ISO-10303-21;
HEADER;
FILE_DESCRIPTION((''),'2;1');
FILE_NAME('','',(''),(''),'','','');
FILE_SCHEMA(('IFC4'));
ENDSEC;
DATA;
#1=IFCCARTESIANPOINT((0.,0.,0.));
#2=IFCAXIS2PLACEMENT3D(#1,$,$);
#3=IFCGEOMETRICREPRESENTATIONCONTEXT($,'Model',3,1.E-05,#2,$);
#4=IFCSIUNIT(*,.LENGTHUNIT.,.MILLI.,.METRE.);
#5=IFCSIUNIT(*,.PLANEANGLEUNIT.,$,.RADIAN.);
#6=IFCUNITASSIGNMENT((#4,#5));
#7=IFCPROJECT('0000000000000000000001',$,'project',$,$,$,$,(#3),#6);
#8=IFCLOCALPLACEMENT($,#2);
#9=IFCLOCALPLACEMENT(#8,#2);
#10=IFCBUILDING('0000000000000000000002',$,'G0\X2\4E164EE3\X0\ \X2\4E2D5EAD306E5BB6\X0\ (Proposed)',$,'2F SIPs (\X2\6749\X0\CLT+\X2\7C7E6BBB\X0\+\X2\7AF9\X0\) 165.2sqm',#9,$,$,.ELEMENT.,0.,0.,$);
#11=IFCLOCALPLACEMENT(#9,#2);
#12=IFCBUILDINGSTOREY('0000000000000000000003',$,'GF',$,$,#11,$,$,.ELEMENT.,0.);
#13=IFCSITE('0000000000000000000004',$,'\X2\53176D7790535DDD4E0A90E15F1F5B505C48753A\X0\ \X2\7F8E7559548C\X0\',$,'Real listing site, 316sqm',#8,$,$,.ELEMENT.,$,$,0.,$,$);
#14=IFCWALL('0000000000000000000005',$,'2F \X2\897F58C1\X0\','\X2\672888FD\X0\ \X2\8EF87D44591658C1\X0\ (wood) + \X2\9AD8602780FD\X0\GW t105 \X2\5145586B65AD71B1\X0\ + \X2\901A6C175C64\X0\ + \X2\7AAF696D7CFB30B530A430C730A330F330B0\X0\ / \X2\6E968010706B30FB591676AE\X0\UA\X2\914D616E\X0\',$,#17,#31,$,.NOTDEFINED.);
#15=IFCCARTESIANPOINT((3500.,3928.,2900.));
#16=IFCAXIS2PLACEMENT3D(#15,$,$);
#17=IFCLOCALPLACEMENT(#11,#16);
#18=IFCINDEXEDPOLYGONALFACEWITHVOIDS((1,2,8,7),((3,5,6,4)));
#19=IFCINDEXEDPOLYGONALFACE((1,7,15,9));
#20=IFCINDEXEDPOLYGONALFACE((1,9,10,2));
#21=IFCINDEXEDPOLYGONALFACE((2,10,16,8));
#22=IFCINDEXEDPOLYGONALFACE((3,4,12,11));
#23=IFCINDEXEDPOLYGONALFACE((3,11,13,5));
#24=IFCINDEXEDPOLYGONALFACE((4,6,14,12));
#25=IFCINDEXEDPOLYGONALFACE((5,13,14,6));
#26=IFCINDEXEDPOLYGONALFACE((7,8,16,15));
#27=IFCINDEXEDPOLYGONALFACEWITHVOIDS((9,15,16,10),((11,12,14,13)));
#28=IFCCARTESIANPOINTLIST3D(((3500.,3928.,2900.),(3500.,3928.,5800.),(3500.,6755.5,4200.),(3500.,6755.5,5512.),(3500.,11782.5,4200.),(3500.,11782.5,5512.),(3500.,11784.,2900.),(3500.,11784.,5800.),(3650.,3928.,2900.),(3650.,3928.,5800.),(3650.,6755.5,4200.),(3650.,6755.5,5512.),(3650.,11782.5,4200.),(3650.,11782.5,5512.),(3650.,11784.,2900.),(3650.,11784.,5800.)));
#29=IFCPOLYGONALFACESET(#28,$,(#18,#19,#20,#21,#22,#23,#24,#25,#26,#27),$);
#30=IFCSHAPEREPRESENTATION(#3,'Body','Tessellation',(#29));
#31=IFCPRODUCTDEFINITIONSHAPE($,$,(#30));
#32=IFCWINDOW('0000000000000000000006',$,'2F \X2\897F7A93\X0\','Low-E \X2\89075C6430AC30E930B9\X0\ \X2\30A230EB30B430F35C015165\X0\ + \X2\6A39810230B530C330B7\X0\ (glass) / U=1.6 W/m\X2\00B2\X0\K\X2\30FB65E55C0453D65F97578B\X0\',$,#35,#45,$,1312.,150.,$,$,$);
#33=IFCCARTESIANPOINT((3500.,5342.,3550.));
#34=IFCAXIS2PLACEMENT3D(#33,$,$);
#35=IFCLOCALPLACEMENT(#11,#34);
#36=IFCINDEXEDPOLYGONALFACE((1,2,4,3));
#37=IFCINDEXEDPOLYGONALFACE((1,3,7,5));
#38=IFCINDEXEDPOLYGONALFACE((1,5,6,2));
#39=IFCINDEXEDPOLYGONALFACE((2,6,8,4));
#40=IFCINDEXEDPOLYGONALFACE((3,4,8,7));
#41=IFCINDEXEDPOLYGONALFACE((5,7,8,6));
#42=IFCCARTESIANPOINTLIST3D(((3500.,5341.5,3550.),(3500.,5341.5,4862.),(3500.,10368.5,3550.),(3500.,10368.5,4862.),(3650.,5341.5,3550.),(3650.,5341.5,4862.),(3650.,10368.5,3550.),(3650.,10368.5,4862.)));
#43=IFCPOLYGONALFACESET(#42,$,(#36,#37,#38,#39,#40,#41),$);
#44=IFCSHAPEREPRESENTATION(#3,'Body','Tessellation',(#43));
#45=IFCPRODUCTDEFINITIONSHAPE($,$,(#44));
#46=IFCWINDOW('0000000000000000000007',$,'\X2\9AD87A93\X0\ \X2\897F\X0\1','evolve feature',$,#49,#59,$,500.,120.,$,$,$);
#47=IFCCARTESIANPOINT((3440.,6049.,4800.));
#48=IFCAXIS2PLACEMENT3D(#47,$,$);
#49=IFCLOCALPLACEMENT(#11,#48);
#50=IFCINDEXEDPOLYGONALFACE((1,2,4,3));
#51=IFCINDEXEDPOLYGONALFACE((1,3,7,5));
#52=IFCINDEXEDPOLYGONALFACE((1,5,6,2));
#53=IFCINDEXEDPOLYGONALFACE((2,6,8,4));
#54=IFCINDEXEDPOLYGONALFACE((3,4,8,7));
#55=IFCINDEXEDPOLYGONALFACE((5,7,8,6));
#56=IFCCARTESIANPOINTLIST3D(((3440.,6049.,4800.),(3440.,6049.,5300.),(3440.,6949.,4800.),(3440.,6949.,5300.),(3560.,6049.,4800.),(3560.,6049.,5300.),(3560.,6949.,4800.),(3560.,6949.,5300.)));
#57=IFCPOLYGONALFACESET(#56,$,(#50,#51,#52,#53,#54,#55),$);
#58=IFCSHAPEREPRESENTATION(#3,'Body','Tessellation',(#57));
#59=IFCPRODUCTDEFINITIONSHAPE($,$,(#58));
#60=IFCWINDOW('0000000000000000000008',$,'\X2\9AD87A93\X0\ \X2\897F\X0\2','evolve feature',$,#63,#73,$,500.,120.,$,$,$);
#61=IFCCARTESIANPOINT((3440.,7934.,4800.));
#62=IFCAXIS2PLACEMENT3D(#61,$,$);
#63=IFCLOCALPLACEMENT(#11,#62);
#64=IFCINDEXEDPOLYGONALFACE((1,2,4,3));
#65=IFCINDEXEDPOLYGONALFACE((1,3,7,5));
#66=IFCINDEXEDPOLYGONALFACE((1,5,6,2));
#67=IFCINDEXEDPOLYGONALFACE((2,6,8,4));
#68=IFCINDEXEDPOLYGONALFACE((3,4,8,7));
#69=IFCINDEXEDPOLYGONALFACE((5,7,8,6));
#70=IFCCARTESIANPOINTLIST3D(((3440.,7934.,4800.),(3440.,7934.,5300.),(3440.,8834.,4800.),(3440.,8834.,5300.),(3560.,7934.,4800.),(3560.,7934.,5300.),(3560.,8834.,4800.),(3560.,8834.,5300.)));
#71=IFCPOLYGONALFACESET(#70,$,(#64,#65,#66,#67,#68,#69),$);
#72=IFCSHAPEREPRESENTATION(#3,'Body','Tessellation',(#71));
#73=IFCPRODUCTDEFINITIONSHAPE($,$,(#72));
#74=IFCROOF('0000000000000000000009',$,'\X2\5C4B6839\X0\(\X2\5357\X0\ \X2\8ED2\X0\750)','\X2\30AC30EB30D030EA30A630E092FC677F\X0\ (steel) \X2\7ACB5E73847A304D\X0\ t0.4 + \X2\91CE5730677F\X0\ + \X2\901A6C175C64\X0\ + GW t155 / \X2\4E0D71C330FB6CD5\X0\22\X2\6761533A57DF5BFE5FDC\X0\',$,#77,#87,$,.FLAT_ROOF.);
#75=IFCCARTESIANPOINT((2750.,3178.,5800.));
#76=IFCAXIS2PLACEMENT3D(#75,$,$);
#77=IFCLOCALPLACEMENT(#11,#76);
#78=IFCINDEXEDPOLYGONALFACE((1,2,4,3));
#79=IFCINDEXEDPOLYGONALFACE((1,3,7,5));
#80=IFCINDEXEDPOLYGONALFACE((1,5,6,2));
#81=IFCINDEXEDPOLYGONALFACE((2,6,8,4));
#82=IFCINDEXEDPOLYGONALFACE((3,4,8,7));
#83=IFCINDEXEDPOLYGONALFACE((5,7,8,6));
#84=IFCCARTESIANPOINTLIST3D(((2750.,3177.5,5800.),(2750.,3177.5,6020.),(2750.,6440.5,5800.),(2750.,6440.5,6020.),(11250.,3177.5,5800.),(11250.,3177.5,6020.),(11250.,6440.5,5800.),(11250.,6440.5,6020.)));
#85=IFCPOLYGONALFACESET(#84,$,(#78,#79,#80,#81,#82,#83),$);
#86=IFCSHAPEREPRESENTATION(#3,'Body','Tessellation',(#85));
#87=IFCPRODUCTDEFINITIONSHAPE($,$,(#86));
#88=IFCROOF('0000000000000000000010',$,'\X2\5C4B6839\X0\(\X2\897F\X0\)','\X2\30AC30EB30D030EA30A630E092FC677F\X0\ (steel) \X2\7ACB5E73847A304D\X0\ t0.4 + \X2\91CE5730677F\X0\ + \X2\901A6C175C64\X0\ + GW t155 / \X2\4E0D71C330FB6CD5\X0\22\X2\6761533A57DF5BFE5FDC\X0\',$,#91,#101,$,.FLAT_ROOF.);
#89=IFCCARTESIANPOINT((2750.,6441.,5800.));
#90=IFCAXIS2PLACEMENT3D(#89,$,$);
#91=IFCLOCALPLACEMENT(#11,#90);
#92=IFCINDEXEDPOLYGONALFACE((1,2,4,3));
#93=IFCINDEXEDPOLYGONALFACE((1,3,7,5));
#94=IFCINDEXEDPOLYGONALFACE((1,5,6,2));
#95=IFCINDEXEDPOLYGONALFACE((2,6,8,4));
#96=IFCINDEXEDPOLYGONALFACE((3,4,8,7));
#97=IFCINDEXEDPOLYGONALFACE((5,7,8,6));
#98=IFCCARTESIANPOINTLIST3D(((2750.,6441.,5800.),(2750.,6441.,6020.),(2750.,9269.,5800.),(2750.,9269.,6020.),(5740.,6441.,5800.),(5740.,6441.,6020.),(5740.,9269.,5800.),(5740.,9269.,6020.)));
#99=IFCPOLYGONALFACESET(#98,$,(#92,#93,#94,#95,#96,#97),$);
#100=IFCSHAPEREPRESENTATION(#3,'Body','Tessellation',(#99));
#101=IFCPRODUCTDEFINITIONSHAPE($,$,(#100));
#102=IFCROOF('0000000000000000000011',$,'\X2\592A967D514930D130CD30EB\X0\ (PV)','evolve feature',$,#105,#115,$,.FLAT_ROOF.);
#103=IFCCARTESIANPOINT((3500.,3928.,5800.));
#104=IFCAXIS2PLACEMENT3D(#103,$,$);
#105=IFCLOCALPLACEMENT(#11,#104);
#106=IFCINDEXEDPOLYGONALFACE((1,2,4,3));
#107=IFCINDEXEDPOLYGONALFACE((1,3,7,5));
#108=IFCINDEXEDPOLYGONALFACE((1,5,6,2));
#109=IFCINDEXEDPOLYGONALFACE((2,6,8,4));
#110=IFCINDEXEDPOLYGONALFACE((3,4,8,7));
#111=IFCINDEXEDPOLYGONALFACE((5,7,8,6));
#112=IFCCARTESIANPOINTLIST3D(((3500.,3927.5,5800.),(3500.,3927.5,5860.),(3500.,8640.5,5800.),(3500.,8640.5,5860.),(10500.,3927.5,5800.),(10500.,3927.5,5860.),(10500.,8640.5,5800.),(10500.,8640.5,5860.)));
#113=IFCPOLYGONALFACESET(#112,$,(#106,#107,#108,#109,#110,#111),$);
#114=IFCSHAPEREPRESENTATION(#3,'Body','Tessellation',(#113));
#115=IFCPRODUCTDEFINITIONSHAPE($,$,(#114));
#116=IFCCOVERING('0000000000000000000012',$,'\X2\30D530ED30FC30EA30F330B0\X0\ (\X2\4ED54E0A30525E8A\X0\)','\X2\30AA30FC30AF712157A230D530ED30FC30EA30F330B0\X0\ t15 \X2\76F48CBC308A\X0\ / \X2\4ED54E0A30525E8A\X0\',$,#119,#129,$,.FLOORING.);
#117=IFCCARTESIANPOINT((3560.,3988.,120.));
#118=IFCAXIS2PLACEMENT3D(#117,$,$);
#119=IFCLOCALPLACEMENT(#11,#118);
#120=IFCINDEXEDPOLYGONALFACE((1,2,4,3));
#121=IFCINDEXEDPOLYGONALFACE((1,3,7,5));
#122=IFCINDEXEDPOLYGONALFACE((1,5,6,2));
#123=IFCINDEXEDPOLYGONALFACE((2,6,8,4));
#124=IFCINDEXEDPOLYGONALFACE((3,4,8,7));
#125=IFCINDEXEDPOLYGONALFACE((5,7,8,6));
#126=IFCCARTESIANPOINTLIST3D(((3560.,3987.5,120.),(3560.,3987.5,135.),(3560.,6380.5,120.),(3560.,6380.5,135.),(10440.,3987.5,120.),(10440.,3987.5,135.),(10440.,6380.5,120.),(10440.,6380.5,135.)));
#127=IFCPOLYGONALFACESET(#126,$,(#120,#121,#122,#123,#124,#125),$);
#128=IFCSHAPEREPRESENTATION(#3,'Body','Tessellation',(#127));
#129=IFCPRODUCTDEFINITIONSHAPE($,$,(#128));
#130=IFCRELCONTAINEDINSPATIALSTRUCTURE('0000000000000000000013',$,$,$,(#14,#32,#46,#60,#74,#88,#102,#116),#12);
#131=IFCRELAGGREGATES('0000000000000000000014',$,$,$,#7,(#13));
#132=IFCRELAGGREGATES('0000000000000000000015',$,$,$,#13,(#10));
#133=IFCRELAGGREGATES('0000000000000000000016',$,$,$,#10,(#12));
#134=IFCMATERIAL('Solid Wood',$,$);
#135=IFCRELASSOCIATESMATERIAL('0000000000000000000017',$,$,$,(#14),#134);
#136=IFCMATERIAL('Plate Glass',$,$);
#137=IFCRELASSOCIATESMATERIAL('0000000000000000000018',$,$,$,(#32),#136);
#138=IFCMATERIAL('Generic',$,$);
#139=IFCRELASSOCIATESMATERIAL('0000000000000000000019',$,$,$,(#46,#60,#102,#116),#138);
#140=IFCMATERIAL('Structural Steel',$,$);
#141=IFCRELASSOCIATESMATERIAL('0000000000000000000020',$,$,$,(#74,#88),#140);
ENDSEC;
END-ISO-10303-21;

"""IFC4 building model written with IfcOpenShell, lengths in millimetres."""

from ifc_helpers import new_model, si_unit, frame, frame_2d, origin, place, context, project, spatial, rectangle, extrude, material, element, fill, save


model = new_model("IFC4")

# Units and contexts
model_context = context("Model", 3, precision=1e-05, world=origin())
ifc_project = project(units=[si_unit("LENGTHUNIT", "METRE", prefix="MILLI"), si_unit("PLANEANGLEUNIT", "RADIAN")], contexts=[model_context])

# Site, building, storey
site_placement = place(None, origin())
site = spatial("IfcSite", under=ifc_project, at=site_placement, Name="北海道川上郡弟子屈町 美留和", ObjectType="Real listing site, 316sqm", CompositionType="ELEMENT", RefElevation=0.0)
building_placement = place(site_placement, origin())
building = spatial("IfcBuilding", under=site, at=building_placement, Name="G0世代 中庭の家 (Proposed)", ObjectType="2F SIPs (杉CLT+籾殻+竹) 165.2sqm", CompositionType="ELEMENT", ElevationOfRefHeight=0.0, ElevationOfTerrain=0.0)
storey_placement = place(building_placement, origin())
storey = spatial("IfcBuildingStorey", under=building, at=storey_placement, Name="GF", CompositionType="ELEMENT", Elevation=0.0)

# Shared definitions
ifc_material_1 = material(Name="Solid Wood")
ifc_material_2 = material(Name="Generic")

# Shared definitions
ifc_material_3 = material(Name="Plate Glass")

# Wall, openings, windows
wall_1_placement = place(storey_placement, frame((3500.0, 3928.0, 2900.0)))
wall_1 = element("IfcWall", 1, at=wall_1_placement, inside=storey, material=ifc_material_1, Name="2F 西壁", Description="木製 軸組外壁 (wood) + 高性能GW t105 充填断熱 + 通気層 + 窯業系サイディング / 準耐火・外皮UA配慮", PredefinedType="NOTDEFINED", context=model_context, shape_type="SweptSolid", body=[
    extrude(rectangle(XDim=150.0, YDim=7856.0, at=frame_2d((75.0, 3928.0))), frame((3500.0, 3928.0, 2900.0)), (0.0, 0.0, 1.0), 2900.0),
])
opening_1_placement = place(storey_placement, frame((3500.0, 5342.0, 3550.0)))
opening_1 = element("IfcOpeningElement", 2, at=opening_1_placement, cuts=wall_1, PredefinedType="NOTDEFINED", context=model_context, shape_type="SweptSolid", body=[
    extrude(rectangle(XDim=150.0, YDim=5027.0, at=frame_2d((75.0, 2513.0))), frame((3500.0, 5342.0, 3550.0)), (0.0, 0.0, 1.0), 1312.0),
])
opening_2_placement = place(storey_placement, frame((3440.0, 6049.0, 4800.0)))
opening_2 = element("IfcOpeningElement", 3, at=opening_2_placement, cuts=wall_1, PredefinedType="NOTDEFINED", context=model_context, shape_type="SweptSolid", body=[
    extrude(rectangle(XDim=120.0, YDim=900.0, at=frame_2d((60.0, 450.0))), frame((3440.0, 6049.0, 4800.0)), (0.0, 0.0, 1.0), 500.0),
])
opening_3_placement = place(storey_placement, frame((3440.0, 7934.0, 4800.0)))
opening_3 = element("IfcOpeningElement", 4, at=opening_3_placement, cuts=wall_1, PredefinedType="NOTDEFINED", context=model_context, shape_type="SweptSolid", body=[
    extrude(rectangle(XDim=120.0, YDim=900.0, at=frame_2d((60.0, 450.0))), frame((3440.0, 7934.0, 4800.0)), (0.0, 0.0, 1.0), 500.0),
])
window_1_placement = place(storey_placement, frame((3500.0, 5342.0, 3550.0)))
window_1 = element("IfcWindow", 5, at=window_1_placement, inside=storey, material=ifc_material_3, Name="2F 西窓", Description="Low-E 複層ガラス アルゴン封入 + 樹脂サッシ (glass) / U=1.6 W/m²K・日射取得型", OverallHeight=1312.0, OverallWidth=150.0, context=model_context, shape_type="SweptSolid", body=[
    extrude(rectangle(XDim=150.0, YDim=5027.0, at=frame_2d((75.0, 2513.0))), frame((3500.0, 5342.0, 3550.0)), (0.0, 0.0, 1.0), 1312.0),
])
fill(opening_1, window_1)
window_2_placement = place(storey_placement, frame((3440.0, 6049.0, 4800.0)))
window_2 = element("IfcWindow", 6, at=window_2_placement, inside=storey, material=ifc_material_2, Name="高窓 西1", Description="evolve feature", OverallHeight=500.0, OverallWidth=120.0, context=model_context, shape_type="SweptSolid", body=[
    extrude(rectangle(XDim=120.0, YDim=900.0, at=frame_2d((60.0, 450.0))), frame((3440.0, 6049.0, 4800.0)), (0.0, 0.0, 1.0), 500.0),
])
fill(opening_2, window_2)
window_3_placement = place(storey_placement, frame((3440.0, 7934.0, 4800.0)))
window_3 = element("IfcWindow", 7, at=window_3_placement, inside=storey, material=ifc_material_2, Name="高窓 西2", Description="evolve feature", OverallHeight=500.0, OverallWidth=120.0, context=model_context, shape_type="SweptSolid", body=[
    extrude(rectangle(XDim=120.0, YDim=900.0, at=frame_2d((60.0, 450.0))), frame((3440.0, 7934.0, 4800.0)), (0.0, 0.0, 1.0), 500.0),
])
fill(opening_3, window_3)

# Roofs
ifc_material_4 = material(Name="Structural Steel")
roof_1_placement = place(storey_placement, frame((2750.0, 3178.0, 5800.0)))
element("IfcRoof", 8, at=roof_1_placement, inside=storey, material=ifc_material_4, Name="屋根(南 軒750)", Description="ガルバリウム鋼板 (steel) 立平葺き t0.4 + 野地板 + 通気層 + GW t155 / 不燃・法22条区域対応", PredefinedType="FLAT_ROOF", context=model_context, shape_type="SweptSolid", body=[
    extrude(rectangle(XDim=8500.0, YDim=3263.0, at=frame_2d((4250.0, 1631.0))), frame((2750.0, 3178.0, 5800.0)), (0.0, 0.0, 1.0), 220.0),
])
roof_2_placement = place(storey_placement, frame((2750.0, 6441.0, 5800.0)))
element("IfcRoof", 9, at=roof_2_placement, inside=storey, material=ifc_material_4, Name="屋根(西)", Description="ガルバリウム鋼板 (steel) 立平葺き t0.4 + 野地板 + 通気層 + GW t155 / 不燃・法22条区域対応", PredefinedType="FLAT_ROOF", context=model_context, shape_type="SweptSolid", body=[
    extrude(rectangle(XDim=2990.0, YDim=2828.0, at=frame_2d((1495.0, 1414.0))), frame((2750.0, 6441.0, 5800.0)), (0.0, 0.0, 1.0), 220.0),
])
roof_3_placement = place(storey_placement, frame((3500.0, 3928.0, 5800.0)))
element("IfcRoof", 10, at=roof_3_placement, inside=storey, material=ifc_material_2, Name="太陽光パネル (PV)", Description="evolve feature", PredefinedType="FLAT_ROOF", context=model_context, shape_type="SweptSolid", body=[
    extrude(rectangle(XDim=7000.0, YDim=4713.0, at=frame_2d((3500.0, 2356.0))), frame((3500.0, 3928.0, 5800.0)), (0.0, 0.0, 1.0), 60.0),
])

# Covering
covering_placement = place(storey_placement, frame((3560.0, 3988.0, 120.0)))
element("IfcCovering", 11, at=covering_placement, inside=storey, material=ifc_material_2, Name="フローリング (仕上げ床)", Description="オーク無垢フローリング t15 直貼り / 仕上げ床", PredefinedType="FLOORING", context=model_context, shape_type="SweptSolid", body=[
    extrude(rectangle(XDim=6880.0, YDim=2393.0, at=frame_2d((3440.0, 1196.0))), frame((3560.0, 3988.0, 120.0)), (0.0, 0.0, 1.0), 15.0),
])

save(model, "model.ifc")
